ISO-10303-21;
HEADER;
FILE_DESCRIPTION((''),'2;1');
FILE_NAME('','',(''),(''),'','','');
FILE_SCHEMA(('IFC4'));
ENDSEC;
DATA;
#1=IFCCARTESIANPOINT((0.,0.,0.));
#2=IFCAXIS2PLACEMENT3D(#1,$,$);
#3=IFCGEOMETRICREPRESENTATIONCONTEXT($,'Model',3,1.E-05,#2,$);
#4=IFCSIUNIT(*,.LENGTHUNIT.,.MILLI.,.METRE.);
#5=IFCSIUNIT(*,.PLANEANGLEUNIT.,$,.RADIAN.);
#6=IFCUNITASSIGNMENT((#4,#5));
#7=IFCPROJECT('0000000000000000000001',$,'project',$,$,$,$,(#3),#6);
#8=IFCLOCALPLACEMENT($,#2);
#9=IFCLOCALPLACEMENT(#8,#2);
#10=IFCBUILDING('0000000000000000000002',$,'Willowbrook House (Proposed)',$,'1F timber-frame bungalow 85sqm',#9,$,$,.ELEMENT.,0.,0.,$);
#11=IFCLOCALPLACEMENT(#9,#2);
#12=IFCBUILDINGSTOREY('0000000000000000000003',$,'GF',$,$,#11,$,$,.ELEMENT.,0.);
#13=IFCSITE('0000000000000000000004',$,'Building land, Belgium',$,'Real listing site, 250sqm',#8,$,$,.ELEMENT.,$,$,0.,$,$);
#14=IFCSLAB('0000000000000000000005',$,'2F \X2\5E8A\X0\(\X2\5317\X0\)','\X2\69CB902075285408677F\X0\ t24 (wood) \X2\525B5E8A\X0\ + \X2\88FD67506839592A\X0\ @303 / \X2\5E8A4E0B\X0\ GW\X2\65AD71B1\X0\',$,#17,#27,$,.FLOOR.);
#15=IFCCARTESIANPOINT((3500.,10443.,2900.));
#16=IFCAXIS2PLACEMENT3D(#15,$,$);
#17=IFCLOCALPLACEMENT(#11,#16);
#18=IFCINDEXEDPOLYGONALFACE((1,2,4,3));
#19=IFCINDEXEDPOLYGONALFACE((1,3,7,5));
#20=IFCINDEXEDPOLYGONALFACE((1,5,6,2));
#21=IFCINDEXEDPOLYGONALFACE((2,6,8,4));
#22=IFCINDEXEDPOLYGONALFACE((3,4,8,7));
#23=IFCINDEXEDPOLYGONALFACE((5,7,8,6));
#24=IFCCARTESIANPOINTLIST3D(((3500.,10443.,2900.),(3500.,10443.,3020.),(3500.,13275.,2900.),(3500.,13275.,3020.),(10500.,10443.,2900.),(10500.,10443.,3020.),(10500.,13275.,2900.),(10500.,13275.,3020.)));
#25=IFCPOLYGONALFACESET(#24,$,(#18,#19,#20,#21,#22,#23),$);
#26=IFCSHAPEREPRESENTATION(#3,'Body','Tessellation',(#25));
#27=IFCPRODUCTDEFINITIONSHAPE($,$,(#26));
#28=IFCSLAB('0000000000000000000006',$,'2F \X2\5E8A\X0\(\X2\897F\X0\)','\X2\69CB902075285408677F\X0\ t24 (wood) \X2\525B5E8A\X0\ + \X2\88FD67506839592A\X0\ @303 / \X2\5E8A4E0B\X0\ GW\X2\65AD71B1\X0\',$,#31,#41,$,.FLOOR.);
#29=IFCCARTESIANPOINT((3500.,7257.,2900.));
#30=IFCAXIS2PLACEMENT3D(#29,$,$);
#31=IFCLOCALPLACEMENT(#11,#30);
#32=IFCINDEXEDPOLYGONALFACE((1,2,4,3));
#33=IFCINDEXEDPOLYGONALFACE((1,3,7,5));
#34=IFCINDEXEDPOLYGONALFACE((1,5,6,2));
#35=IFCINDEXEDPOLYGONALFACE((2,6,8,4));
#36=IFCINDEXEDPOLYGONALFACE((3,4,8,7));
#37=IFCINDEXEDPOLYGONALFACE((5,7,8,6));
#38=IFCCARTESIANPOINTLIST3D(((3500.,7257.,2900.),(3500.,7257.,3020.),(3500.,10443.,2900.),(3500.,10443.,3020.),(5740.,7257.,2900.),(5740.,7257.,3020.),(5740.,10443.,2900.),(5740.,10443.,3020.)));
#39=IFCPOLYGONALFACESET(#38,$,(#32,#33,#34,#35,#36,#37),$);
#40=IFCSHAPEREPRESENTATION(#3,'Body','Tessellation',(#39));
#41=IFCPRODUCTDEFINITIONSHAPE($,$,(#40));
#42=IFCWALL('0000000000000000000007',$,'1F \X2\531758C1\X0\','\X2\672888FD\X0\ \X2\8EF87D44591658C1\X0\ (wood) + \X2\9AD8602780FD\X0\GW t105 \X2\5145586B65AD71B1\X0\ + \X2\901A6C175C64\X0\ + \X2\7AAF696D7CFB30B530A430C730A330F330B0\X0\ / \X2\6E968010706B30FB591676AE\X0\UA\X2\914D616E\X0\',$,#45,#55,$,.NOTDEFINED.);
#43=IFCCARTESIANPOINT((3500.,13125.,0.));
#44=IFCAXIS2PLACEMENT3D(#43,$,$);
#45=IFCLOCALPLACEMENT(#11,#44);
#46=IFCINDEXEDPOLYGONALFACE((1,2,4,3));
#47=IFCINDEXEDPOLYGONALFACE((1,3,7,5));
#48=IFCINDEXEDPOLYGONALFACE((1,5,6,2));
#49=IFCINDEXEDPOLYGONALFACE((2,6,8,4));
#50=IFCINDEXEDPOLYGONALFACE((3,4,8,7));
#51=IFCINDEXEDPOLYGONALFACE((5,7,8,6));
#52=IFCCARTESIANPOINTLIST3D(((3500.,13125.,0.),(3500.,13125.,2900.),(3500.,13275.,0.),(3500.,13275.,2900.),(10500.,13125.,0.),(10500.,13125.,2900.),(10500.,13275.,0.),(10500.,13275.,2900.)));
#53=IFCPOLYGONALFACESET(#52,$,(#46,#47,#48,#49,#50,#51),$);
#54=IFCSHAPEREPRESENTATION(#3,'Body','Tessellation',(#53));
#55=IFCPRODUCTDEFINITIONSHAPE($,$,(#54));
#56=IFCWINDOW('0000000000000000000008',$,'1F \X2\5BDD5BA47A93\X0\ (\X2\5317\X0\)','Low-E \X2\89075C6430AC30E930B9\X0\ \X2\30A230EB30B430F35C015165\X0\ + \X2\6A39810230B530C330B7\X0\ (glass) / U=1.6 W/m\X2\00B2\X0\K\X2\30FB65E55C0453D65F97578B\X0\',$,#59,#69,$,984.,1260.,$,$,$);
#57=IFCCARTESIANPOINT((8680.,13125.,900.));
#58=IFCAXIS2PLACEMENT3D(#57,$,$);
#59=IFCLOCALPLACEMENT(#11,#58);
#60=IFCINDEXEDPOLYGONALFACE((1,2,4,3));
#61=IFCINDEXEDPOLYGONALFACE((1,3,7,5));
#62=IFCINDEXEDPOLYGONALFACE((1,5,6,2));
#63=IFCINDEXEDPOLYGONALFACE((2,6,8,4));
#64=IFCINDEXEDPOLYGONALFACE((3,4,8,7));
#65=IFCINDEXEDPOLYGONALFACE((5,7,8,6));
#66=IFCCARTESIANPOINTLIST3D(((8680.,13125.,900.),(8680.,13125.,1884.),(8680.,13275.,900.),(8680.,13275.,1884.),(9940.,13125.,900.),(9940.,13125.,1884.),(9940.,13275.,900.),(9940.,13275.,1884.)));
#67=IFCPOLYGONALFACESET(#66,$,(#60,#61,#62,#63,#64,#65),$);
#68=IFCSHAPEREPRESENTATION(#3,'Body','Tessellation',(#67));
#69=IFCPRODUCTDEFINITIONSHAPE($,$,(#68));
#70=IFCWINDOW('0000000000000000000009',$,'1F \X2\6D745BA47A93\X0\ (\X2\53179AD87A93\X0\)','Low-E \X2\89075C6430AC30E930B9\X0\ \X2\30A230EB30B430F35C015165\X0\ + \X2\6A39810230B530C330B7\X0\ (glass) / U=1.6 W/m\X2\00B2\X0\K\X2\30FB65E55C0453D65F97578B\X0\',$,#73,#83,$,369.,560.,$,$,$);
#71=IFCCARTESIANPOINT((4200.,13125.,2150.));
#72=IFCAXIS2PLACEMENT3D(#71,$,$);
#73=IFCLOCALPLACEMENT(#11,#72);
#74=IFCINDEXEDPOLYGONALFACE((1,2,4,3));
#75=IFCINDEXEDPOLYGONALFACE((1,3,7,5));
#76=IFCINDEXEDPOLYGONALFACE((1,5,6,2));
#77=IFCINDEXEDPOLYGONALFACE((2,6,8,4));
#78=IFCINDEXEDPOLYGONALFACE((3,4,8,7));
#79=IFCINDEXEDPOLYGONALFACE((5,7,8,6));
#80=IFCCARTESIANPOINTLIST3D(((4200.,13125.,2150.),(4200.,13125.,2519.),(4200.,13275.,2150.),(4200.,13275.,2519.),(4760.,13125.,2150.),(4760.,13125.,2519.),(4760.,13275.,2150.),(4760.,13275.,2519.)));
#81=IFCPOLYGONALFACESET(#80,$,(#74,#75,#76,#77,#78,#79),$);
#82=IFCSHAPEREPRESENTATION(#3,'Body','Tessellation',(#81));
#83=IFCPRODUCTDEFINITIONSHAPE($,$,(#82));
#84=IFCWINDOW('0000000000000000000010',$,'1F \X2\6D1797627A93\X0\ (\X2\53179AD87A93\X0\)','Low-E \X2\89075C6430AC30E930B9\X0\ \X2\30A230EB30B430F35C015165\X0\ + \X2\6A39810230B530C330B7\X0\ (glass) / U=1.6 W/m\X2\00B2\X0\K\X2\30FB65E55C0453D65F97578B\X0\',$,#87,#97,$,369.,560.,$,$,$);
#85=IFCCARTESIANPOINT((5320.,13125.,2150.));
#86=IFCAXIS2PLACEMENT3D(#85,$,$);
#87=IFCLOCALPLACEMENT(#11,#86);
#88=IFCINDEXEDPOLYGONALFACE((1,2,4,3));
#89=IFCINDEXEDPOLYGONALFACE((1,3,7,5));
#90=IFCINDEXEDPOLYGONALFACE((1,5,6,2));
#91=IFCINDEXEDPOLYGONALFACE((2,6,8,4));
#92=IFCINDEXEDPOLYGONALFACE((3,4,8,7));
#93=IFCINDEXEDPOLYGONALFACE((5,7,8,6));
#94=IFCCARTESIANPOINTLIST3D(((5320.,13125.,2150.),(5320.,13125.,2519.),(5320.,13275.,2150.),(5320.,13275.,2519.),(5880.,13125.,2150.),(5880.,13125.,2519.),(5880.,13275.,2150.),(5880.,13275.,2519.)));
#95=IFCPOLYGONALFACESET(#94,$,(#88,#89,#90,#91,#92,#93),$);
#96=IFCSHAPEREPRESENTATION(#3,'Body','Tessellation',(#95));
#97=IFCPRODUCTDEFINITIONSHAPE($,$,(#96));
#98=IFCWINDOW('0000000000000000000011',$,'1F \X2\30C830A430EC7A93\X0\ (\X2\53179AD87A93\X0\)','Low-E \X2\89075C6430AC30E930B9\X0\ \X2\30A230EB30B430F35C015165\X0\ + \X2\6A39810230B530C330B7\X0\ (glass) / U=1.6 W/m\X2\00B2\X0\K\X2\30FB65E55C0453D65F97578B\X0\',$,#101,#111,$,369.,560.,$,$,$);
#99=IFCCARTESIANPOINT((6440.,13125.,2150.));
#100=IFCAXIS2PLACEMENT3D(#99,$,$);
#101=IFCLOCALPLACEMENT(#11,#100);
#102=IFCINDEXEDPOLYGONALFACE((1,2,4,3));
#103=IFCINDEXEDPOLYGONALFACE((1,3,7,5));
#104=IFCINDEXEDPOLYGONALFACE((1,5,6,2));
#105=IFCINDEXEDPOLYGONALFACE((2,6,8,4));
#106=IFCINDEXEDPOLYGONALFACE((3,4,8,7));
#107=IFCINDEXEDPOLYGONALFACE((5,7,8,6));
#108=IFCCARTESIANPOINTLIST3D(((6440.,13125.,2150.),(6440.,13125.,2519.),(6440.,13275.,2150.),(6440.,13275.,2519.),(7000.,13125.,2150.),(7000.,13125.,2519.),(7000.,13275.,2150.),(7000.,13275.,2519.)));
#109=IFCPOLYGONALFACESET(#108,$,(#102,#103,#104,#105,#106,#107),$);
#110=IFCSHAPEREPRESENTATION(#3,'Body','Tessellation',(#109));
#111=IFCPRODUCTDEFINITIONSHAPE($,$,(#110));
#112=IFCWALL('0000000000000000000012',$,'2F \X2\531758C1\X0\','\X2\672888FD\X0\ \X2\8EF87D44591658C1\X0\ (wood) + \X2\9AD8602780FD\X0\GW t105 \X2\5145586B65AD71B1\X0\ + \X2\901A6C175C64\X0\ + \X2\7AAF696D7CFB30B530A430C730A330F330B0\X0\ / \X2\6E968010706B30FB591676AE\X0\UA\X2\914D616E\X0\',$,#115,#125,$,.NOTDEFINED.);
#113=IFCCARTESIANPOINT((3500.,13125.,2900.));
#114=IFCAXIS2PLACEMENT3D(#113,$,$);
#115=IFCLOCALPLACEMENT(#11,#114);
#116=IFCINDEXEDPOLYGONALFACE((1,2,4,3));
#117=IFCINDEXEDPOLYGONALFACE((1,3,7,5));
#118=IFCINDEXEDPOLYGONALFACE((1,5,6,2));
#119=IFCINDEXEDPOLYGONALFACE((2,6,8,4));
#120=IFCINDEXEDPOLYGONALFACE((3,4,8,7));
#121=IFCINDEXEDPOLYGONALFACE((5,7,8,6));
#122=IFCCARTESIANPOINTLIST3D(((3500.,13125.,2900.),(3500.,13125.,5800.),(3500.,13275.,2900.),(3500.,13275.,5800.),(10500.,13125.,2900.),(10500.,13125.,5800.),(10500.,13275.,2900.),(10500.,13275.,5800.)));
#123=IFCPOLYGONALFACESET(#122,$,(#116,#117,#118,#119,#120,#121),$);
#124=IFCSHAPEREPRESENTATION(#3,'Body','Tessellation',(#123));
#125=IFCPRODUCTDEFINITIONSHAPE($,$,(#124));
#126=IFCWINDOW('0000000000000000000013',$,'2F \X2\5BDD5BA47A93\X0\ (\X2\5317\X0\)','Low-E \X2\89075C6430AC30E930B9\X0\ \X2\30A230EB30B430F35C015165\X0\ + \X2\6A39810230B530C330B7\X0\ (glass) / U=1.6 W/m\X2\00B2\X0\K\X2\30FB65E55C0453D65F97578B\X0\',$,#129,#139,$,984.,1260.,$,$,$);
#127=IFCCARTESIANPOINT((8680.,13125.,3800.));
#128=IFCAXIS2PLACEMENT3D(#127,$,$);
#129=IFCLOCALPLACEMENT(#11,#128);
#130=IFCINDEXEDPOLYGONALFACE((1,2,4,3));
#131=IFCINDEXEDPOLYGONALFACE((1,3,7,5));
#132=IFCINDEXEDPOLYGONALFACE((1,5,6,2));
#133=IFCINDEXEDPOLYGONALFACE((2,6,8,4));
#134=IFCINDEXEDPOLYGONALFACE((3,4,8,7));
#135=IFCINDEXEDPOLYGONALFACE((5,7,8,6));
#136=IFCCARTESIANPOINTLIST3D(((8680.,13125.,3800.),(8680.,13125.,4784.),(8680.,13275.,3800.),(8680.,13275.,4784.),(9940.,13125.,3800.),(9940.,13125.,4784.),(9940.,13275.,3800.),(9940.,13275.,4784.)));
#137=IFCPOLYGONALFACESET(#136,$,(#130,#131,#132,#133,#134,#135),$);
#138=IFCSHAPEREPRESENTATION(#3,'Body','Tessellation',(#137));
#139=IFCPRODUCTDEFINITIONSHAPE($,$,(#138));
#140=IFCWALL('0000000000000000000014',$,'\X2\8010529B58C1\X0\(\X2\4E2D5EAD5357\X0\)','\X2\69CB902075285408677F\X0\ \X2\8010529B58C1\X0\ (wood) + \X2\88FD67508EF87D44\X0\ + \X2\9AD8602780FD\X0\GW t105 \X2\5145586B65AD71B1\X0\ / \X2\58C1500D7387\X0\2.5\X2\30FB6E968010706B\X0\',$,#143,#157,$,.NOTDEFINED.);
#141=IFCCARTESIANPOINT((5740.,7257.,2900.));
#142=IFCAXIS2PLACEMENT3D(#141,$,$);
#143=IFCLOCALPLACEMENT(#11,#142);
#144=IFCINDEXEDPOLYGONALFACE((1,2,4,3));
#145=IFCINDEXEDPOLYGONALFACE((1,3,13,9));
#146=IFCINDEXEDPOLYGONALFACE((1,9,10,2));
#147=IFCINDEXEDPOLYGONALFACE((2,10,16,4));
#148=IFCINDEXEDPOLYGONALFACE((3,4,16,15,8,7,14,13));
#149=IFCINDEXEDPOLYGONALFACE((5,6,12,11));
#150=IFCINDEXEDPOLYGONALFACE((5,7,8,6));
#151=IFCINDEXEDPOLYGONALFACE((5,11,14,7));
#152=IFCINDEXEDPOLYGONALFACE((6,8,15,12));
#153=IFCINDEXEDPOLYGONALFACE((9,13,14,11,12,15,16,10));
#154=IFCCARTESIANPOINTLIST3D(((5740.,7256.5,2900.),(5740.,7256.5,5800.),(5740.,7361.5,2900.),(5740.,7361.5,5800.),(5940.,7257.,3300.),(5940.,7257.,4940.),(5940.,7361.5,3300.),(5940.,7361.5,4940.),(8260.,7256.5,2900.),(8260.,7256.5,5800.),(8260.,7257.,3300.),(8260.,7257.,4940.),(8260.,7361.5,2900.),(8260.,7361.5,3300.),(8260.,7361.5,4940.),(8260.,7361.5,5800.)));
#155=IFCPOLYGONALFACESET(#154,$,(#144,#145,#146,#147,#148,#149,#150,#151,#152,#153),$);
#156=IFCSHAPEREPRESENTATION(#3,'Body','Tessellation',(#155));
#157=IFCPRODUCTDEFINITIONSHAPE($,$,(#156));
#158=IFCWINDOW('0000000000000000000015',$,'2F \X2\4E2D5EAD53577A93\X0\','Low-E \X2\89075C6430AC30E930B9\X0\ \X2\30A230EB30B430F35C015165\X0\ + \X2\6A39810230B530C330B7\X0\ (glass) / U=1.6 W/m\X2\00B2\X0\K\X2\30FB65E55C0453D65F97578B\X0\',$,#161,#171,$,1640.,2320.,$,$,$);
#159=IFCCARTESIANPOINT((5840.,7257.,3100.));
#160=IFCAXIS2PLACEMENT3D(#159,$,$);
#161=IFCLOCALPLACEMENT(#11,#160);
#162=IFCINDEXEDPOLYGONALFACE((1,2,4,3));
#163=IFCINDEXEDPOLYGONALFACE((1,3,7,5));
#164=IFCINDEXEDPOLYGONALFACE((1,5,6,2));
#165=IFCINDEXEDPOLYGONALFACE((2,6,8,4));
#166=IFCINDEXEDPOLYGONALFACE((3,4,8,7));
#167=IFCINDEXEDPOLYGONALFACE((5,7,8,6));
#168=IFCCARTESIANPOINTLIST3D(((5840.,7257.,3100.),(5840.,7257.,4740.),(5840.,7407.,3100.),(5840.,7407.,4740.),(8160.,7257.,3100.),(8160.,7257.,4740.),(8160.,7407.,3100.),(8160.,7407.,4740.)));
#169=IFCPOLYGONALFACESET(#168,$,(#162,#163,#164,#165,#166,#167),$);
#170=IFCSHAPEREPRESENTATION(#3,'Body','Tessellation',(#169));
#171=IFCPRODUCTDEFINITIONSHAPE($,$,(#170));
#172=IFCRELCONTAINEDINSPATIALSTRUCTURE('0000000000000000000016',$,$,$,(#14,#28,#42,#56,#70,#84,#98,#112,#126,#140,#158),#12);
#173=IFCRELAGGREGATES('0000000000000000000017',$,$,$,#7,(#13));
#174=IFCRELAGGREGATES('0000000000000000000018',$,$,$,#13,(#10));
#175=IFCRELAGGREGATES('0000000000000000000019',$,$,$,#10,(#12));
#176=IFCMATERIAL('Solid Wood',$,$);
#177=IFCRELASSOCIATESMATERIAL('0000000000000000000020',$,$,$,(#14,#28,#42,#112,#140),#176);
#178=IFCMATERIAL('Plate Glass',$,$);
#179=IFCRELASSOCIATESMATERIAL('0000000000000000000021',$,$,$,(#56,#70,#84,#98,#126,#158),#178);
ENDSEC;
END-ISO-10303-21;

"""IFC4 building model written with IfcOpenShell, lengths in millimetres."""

from ifc_helpers import new_model, si_unit, frame, frame_2d, origin, place, context, project, spatial, rectangle, extrude, material, element, fill, save


model = new_model("IFC4")

# Units and contexts
model_context = context("Model", 3, precision=1e-05, world=origin())
ifc_project = project(units=[si_unit("LENGTHUNIT", "METRE", prefix="MILLI"), si_unit("PLANEANGLEUNIT", "RADIAN")], contexts=[model_context])

# Site, building, storey
site_placement = place(None, origin())
site = spatial("IfcSite", under=ifc_project, at=site_placement, Name="Building land, Belgium", ObjectType="Real listing site, 250sqm", CompositionType="ELEMENT", RefElevation=0.0)
building_placement = place(site_placement, origin())
building = spatial("IfcBuilding", under=site, at=building_placement, Name="Willowbrook House (Proposed)", ObjectType="1F timber-frame bungalow 85sqm", CompositionType="ELEMENT", ElevationOfRefHeight=0.0, ElevationOfTerrain=0.0)
storey_placement = place(building_placement, origin())
storey = spatial("IfcBuildingStorey", under=building, at=storey_placement, Name="GF", CompositionType="ELEMENT", Elevation=0.0)

# Slabs
ifc_material_1 = material(Name="Solid Wood")
slab_1_placement = place(storey_placement, frame((3500.0, 10443.0, 2900.0)))
element("IfcSlab", 1, at=slab_1_placement, inside=storey, material=ifc_material_1, Name="2F 床(北)", Description="構造用合板 t24 (wood) 剛床 + 製材根太 @303 / 床下 GW断熱", PredefinedType="FLOOR", context=model_context, shape_type="SweptSolid", body=[
    extrude(rectangle(XDim=7000.0, YDim=2832.0, at=frame_2d((3500.0, 1416.0))), frame((3500.0, 10443.0, 2900.0)), (0.0, 0.0, 1.0), 120.0),
])
slab_2_placement = place(storey_placement, frame((3500.0, 7257.0, 2900.0)))
element("IfcSlab", 2, at=slab_2_placement, inside=storey, material=ifc_material_1, Name="2F 床(西)", Description="構造用合板 t24 (wood) 剛床 + 製材根太 @303 / 床下 GW断熱", PredefinedType="FLOOR", context=model_context, shape_type="SweptSolid", body=[
    extrude(rectangle(XDim=2240.0, YDim=3186.0, at=frame_2d((1120.0, 1593.0))), frame((3500.0, 7257.0, 2900.0)), (0.0, 0.0, 1.0), 120.0),
])

# Wall, openings, windows
wall_1_placement = place(storey_placement, frame((3500.0, 13125.0, 0.0)))
wall_1 = element("IfcWall", 3, at=wall_1_placement, inside=storey, material=ifc_material_1, Name="1F 北壁", Description="木製 軸組外壁 (wood) + 高性能GW t105 充填断熱 + 通気層 + 窯業系サイディング / 準耐火・外皮UA配慮", PredefinedType="NOTDEFINED", context=model_context, shape_type="SweptSolid", body=[
    extrude(rectangle(XDim=7000.0, YDim=150.0, at=frame_2d((3500.0, 75.0))), frame((3500.0, 13125.0, 0.0)), (0.0, 0.0, 1.0), 2900.0),
])
opening_1_placement = place(storey_placement, frame((8680.0, 13125.0, 900.0)))
opening_1 = element("IfcOpeningElement", 4, at=opening_1_placement, cuts=wall_1, PredefinedType="NOTDEFINED", context=model_context, shape_type="SweptSolid", body=[
    extrude(rectangle(XDim=1260.0, YDim=150.0, at=frame_2d((630.0, 75.0))), frame((8680.0, 13125.0, 900.0)), (0.0, 0.0, 1.0), 984.0),
])
opening_2_placement = place(storey_placement, frame((4200.0, 13125.0, 2150.0)))
opening_2 = element("IfcOpeningElement", 5, at=opening_2_placement, cuts=wall_1, PredefinedType="NOTDEFINED", context=model_context, shape_type="SweptSolid", body=[
    extrude(rectangle(XDim=560.0, YDim=150.0, at=frame_2d((280.0, 75.0))), frame((4200.0, 13125.0, 2150.0)), (0.0, 0.0, 1.0), 369.0),
])
opening_3_placement = place(storey_placement, frame((5320.0, 13125.0, 2150.0)))
opening_3 = element("IfcOpeningElement", 6, at=opening_3_placement, cuts=wall_1, PredefinedType="NOTDEFINED", context=model_context, shape_type="SweptSolid", body=[
    extrude(rectangle(XDim=560.0, YDim=150.0, at=frame_2d((280.0, 75.0))), frame((5320.0, 13125.0, 2150.0)), (0.0, 0.0, 1.0), 369.0),
])
opening_4_placement = place(storey_placement, frame((6440.0, 13125.0, 2150.0)))
opening_4 = element("IfcOpeningElement", 7, at=opening_4_placement, cuts=wall_1, PredefinedType="NOTDEFINED", context=model_context, shape_type="SweptSolid", body=[
    extrude(rectangle(XDim=560.0, YDim=150.0, at=frame_2d((280.0, 75.0))), frame((6440.0, 13125.0, 2150.0)), (0.0, 0.0, 1.0), 369.0),
])
ifc_material_2 = material(Name="Plate Glass")
window_1_placement = place(storey_placement, frame((8680.0, 13125.0, 900.0)))
window_1 = element("IfcWindow", 8, at=window_1_placement, inside=storey, material=ifc_material_2, Name="1F 寝室窓 (北)", Description="Low-E 複層ガラス アルゴン封入 + 樹脂サッシ (glass) / U=1.6 W/m²K・日射取得型", OverallHeight=984.0, OverallWidth=1260.0, context=model_context, shape_type="SweptSolid", body=[
    extrude(rectangle(XDim=1260.0, YDim=150.0, at=frame_2d((630.0, 75.0))), frame((8680.0, 13125.0, 900.0)), (0.0, 0.0, 1.0), 984.0),
])
fill(opening_1, window_1)
window_2_placement = place(storey_placement, frame((4200.0, 13125.0, 2150.0)))
window_2 = element("IfcWindow", 9, at=window_2_placement, inside=storey, material=ifc_material_2, Name="1F 浴室窓 (北高窓)", Description="Low-E 複層ガラス アルゴン封入 + 樹脂サッシ (glass) / U=1.6 W/m²K・日射取得型", OverallHeight=369.0, OverallWidth=560.0, context=model_context, shape_type="SweptSolid", body=[
    extrude(rectangle(XDim=560.0, YDim=150.0, at=frame_2d((280.0, 75.0))), frame((4200.0, 13125.0, 2150.0)), (0.0, 0.0, 1.0), 369.0),
])
fill(opening_2, window_2)
window_3_placement = place(storey_placement, frame((5320.0, 13125.0, 2150.0)))
window_3 = element("IfcWindow", 10, at=window_3_placement, inside=storey, material=ifc_material_2, Name="1F 洗面窓 (北高窓)", Description="Low-E 複層ガラス アルゴン封入 + 樹脂サッシ (glass) / U=1.6 W/m²K・日射取得型", OverallHeight=369.0, OverallWidth=560.0, context=model_context, shape_type="SweptSolid", body=[
    extrude(rectangle(XDim=560.0, YDim=150.0, at=frame_2d((280.0, 75.0))), frame((5320.0, 13125.0, 2150.0)), (0.0, 0.0, 1.0), 369.0),
])
fill(opening_3, window_3)
window_4_placement = place(storey_placement, frame((6440.0, 13125.0, 2150.0)))
window_4 = element("IfcWindow", 11, at=window_4_placement, inside=storey, material=ifc_material_2, Name="1F トイレ窓 (北高窓)", Description="Low-E 複層ガラス アルゴン封入 + 樹脂サッシ (glass) / U=1.6 W/m²K・日射取得型", OverallHeight=369.0, OverallWidth=560.0, context=model_context, shape_type="SweptSolid", body=[
    extrude(rectangle(XDim=560.0, YDim=150.0, at=frame_2d((280.0, 75.0))), frame((6440.0, 13125.0, 2150.0)), (0.0, 0.0, 1.0), 369.0),
])
fill(opening_4, window_4)

# Walls, openings, windows
wall_2_placement = place(storey_placement, frame((3500.0, 13125.0, 2900.0)))
wall_2 = element("IfcWall", 12, at=wall_2_placement, inside=storey, material=ifc_material_1, Name="2F 北壁", Description="木製 軸組外壁 (wood) + 高性能GW t105 充填断熱 + 通気層 + 窯業系サイディング / 準耐火・外皮UA配慮", PredefinedType="NOTDEFINED", context=model_context, shape_type="SweptSolid", body=[
    extrude(rectangle(XDim=7000.0, YDim=150.0, at=frame_2d((3500.0, 75.0))), frame((3500.0, 13125.0, 2900.0)), (0.0, 0.0, 1.0), 2900.0),
])
opening_5_placement = place(storey_placement, frame((8680.0, 13125.0, 3800.0)))
opening_5 = element("IfcOpeningElement", 13, at=opening_5_placement, cuts=wall_2, PredefinedType="NOTDEFINED", context=model_context, shape_type="SweptSolid", body=[
    extrude(rectangle(XDim=1260.0, YDim=150.0, at=frame_2d((630.0, 75.0))), frame((8680.0, 13125.0, 3800.0)), (0.0, 0.0, 1.0), 984.0),
])
window_5_placement = place(storey_placement, frame((8680.0, 13125.0, 3800.0)))
window_5 = element("IfcWindow", 14, at=window_5_placement, inside=storey, material=ifc_material_2, Name="2F 寝室窓 (北)", Description="Low-E 複層ガラス アルゴン封入 + 樹脂サッシ (glass) / U=1.6 W/m²K・日射取得型", OverallHeight=984.0, OverallWidth=1260.0, context=model_context, shape_type="SweptSolid", body=[
    extrude(rectangle(XDim=1260.0, YDim=150.0, at=frame_2d((630.0, 75.0))), frame((8680.0, 13125.0, 3800.0)), (0.0, 0.0, 1.0), 984.0),
])
fill(opening_5, window_5)
wall_3_placement = place(storey_placement, frame((5740.0, 7257.0, 2900.0)))
wall_3 = element("IfcWall", 15, at=wall_3_placement, inside=storey, material=ifc_material_1, Name="耐力壁(中庭南)", Description="構造用合板 耐力壁 (wood) + 製材軸組 + 高性能GW t105 充填断熱 / 壁倍率2.5・準耐火", PredefinedType="NOTDEFINED", context=model_context, shape_type="SweptSolid", body=[
    extrude(rectangle(XDim=2520.0, YDim=105.0, at=frame_2d((1260.0, 52.0))), frame((5740.0, 7257.0, 2900.0)), (0.0, 0.0, 1.0), 2900.0),
])
opening_6_placement = place(storey_placement, frame((5840.0, 7257.0, 3100.0)))
opening_6 = element("IfcOpeningElement", 16, at=opening_6_placement, cuts=wall_3, PredefinedType="NOTDEFINED", context=model_context, shape_type="SweptSolid", body=[
    extrude(rectangle(XDim=2320.0, YDim=150.0, at=frame_2d((1160.0, 75.0))), frame((5840.0, 7257.0, 3100.0)), (0.0, 0.0, 1.0), 1640.0),
])
window_6_placement = place(storey_placement, frame((5840.0, 7257.0, 3100.0)))
window_6 = element("IfcWindow", 17, at=window_6_placement, inside=storey, material=ifc_material_2, Name="2F 中庭南窓", Description="Low-E 複層ガラス アルゴン封入 + 樹脂サッシ (glass) / U=1.6 W/m²K・日射取得型", OverallHeight=1640.0, OverallWidth=2320.0, context=model_context, shape_type="SweptSolid", body=[
    extrude(rectangle(XDim=2320.0, YDim=150.0, at=frame_2d((1160.0, 75.0))), frame((5840.0, 7257.0, 3100.0)), (0.0, 0.0, 1.0), 1640.0),
])
fill(opening_6, window_6)

save(model, "model.ifc")
